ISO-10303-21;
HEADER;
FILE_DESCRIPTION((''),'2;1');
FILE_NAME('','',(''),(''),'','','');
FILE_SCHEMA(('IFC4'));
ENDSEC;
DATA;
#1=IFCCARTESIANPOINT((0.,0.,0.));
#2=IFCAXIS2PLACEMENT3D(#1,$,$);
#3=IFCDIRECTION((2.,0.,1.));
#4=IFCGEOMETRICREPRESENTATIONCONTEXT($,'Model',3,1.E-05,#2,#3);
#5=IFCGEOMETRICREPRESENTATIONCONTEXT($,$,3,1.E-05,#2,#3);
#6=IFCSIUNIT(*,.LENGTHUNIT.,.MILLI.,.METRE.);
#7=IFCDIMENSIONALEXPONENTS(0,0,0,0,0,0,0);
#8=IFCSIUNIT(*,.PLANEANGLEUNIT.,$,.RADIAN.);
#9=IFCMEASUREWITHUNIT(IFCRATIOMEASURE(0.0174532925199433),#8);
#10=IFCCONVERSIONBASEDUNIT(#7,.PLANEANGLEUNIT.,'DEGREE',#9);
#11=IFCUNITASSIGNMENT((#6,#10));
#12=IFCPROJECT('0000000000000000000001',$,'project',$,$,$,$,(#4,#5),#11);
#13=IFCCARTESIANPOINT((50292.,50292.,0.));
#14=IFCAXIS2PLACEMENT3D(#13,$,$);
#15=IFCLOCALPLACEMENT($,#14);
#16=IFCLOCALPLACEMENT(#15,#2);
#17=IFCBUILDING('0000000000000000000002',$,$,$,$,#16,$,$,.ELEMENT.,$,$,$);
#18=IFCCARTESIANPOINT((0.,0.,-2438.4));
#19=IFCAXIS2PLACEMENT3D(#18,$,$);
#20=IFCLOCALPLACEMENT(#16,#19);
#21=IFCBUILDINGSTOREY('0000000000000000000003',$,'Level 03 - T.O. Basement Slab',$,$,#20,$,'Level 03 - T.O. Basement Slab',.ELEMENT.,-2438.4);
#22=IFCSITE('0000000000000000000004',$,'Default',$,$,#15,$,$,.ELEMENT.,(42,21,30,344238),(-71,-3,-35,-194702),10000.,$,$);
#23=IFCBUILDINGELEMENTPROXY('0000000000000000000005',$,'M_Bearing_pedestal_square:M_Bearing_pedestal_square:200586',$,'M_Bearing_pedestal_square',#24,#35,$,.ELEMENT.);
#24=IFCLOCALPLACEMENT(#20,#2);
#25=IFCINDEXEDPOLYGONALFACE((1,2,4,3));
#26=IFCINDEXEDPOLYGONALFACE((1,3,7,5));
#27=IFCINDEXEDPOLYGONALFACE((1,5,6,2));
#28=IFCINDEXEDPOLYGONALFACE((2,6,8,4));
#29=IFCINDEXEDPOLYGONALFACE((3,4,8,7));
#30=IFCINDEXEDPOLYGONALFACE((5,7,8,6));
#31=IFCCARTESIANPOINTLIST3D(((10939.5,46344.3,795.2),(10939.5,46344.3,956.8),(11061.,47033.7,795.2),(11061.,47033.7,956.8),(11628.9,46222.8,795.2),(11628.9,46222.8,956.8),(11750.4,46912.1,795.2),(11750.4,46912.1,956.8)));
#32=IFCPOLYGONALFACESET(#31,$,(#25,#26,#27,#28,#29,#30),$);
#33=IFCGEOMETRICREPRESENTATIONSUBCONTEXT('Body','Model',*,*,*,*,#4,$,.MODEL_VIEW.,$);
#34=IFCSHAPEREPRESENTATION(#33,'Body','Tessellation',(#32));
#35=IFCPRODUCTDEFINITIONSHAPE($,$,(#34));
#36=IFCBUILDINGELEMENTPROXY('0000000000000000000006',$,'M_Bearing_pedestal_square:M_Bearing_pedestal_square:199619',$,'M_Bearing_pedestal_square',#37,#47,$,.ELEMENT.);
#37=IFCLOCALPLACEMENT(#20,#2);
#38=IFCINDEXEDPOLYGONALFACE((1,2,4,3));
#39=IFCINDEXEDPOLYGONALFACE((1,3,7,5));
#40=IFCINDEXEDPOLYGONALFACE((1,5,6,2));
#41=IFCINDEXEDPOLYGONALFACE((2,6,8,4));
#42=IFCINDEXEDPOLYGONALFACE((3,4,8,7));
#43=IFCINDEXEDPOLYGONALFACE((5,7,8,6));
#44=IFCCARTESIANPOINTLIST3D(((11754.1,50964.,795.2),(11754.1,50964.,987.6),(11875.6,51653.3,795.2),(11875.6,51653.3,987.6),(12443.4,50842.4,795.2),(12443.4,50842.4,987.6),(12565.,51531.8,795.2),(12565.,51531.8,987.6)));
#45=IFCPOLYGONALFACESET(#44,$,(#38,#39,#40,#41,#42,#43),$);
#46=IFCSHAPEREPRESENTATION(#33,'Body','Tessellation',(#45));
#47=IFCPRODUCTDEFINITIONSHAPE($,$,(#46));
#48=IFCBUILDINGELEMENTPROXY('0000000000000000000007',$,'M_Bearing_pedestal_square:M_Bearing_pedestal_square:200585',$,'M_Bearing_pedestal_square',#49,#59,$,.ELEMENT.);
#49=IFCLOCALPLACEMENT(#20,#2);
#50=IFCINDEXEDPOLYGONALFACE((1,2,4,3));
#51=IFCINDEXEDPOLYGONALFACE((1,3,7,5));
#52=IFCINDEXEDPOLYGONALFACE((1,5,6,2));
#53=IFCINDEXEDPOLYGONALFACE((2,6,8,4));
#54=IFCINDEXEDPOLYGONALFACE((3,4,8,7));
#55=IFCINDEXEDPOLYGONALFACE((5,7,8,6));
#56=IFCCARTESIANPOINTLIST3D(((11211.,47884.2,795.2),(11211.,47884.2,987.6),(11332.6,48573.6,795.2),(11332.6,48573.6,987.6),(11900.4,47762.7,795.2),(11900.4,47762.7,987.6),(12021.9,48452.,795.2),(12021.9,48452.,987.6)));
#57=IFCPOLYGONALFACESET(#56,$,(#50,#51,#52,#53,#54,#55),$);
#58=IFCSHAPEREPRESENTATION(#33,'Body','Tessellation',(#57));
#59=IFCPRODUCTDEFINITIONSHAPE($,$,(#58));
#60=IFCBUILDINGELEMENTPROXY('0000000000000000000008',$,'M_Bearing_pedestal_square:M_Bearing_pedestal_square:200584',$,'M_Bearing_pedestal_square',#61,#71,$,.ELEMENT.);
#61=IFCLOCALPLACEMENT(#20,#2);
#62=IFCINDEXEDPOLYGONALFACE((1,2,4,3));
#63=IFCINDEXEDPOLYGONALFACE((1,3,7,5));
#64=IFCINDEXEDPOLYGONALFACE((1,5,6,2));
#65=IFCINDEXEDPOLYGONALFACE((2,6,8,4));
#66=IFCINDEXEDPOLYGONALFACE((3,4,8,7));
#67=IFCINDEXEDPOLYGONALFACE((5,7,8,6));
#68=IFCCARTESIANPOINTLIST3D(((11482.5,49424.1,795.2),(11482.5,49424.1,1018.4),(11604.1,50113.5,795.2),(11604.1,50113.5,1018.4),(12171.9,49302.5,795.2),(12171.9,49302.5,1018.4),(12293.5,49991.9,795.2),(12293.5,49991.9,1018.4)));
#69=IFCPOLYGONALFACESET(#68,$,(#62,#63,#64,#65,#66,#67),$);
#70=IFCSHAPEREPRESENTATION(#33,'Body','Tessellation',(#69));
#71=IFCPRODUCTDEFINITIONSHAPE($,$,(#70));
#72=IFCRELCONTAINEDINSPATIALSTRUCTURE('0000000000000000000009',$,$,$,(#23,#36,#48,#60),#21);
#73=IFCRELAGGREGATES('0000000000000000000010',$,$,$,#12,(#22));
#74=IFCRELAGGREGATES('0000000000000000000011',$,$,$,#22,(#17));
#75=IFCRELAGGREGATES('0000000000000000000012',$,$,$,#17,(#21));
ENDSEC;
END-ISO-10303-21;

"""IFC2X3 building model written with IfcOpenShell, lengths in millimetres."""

from ifc_helpers import new_model, entity, si_unit, converted_unit, direction, frame, origin, origin_2d_with_axis, place, context, subcontext, project, spatial, rectangle, extrude, source, transform, mapped, element, save


model = new_model("IFC2X3")

# Units and contexts
model_context = context("Model", 3, precision=1e-05, world=origin(), true_north=direction((2.0, 0.0, 1.0)))
context_of_model = context(None, 3, precision=1e-05, world=origin(), true_north=direction((2.0, 0.0, 1.0)))
body_context = subcontext(model_context, "Body", "Model", "MODEL_VIEW")
ifc_project = project(units=[si_unit("LENGTHUNIT", "METRE", prefix="MILLI"), converted_unit("PLANEANGLEUNIT", "DEGREE", entity("IfcRatioMeasure", 0.0174532925199433), si_unit("PLANEANGLEUNIT", "RADIAN"), dimensions=[0, 0, 0, 0, 0, 0, 0])], contexts=[model_context, context_of_model])

# Site, building, storey
site_placement = place(None, frame((50292.0, 50292.0, 0.0)))
site = spatial("IfcSite", under=ifc_project, at=site_placement, Name="Default", CompositionType="ELEMENT", RefLatitude=(42, 21, 30, 344238), RefLongitude=(-71, -3, -35, -194702), RefElevation=10000.0)
building_placement = place(site_placement, origin())
building = spatial("IfcBuilding", under=site, at=building_placement, CompositionType="ELEMENT")
storey_placement = place(building_placement, frame((0.0, 0.0, -2438.4)))
storey = spatial("IfcBuildingStorey", under=building, at=storey_placement, Name="Level 03 - T.O. Basement Slab", LongName="Level 03 - T.O. Basement Slab", CompositionType="ELEMENT", Elevation=-2438.4)

# Building element proxies
shared_shape_1 = source(origin(), body_context, "Body", "SweptSolid", [
    extrude(rectangle(XDim=700.0, YDim=700.0, at=origin_2d_with_axis()), frame((0.0, 0.0, -161.6)), (0.0, 0.0, 1.0), 161.6),
])
for number, where, z_axis, x_axis, name in (
    (1, (11345.0, 46628.2, 956.8), (0.0, 0.0, 1.0), (0.173648, 0.984808, 0.0), "M_Bearing_pedestal_square:M_Bearing_pedestal_square:200586"),
):
    element("IfcBuildingElementProxy", number, at=place(storey_placement, frame(where, z_axis=z_axis, x_axis=x_axis)), inside=storey, Name=name, ObjectType="M_Bearing_pedestal_square", CompositionType="ELEMENT", context=body_context, shape_type="MappedRepresentation", body=[
        mapped(shared_shape_1, transform((0.0, 0.0, 0.0), scale=1.0)),
    ])
shared_shape_2 = source(origin(), body_context, "Body", "SweptSolid", [
    extrude(rectangle(XDim=700.0, YDim=700.0, at=origin_2d_with_axis()), frame((0.0, 0.0, -192.4)), (0.0, 0.0, 1.0), 192.4),
])
for number, where, z_axis, x_axis, name in (
    (2, (12159.5, 51247.9, 987.6), (0.0, 0.0, 1.0), (0.173648, 0.984808, 0.0), "M_Bearing_pedestal_square:M_Bearing_pedestal_square:199619"),
    (3, (11616.5, 48168.1, 987.6), (0.0, 0.0, 1.0), (0.173648, 0.984808, 0.0), "M_Bearing_pedestal_square:M_Bearing_pedestal_square:200585"),
):
    element("IfcBuildingElementProxy", number, at=place(storey_placement, frame(where, z_axis=z_axis, x_axis=x_axis)), inside=storey, Name=name, ObjectType="M_Bearing_pedestal_square", CompositionType="ELEMENT", context=body_context, shape_type="MappedRepresentation", body=[
        mapped(shared_shape_2, transform((0.0, 0.0, 0.0), scale=1.0)),
    ])
shared_shape_3 = source(origin(), body_context, "Body", "SweptSolid", [
    extrude(rectangle(XDim=700.0, YDim=700.0, at=origin_2d_with_axis()), frame((0.0, 0.0, -223.2)), (0.0, 0.0, 1.0), 223.2),
])
proxy_placement = place(storey_placement, frame((11888.0, 49708.0, 1018.4), z_axis=(0.0, 0.0, 1.0), x_axis=(0.173648, 0.984808, 0.0)))
element("IfcBuildingElementProxy", 4, at=proxy_placement, inside=storey, Name="M_Bearing_pedestal_square:M_Bearing_pedestal_square:200584", ObjectType="M_Bearing_pedestal_square", CompositionType="ELEMENT", context=body_context, shape_type="MappedRepresentation", body=[
    mapped(shared_shape_3, transform((0.0, 0.0, 0.0), scale=1.0)),
])

save(model, "model.ifc")
